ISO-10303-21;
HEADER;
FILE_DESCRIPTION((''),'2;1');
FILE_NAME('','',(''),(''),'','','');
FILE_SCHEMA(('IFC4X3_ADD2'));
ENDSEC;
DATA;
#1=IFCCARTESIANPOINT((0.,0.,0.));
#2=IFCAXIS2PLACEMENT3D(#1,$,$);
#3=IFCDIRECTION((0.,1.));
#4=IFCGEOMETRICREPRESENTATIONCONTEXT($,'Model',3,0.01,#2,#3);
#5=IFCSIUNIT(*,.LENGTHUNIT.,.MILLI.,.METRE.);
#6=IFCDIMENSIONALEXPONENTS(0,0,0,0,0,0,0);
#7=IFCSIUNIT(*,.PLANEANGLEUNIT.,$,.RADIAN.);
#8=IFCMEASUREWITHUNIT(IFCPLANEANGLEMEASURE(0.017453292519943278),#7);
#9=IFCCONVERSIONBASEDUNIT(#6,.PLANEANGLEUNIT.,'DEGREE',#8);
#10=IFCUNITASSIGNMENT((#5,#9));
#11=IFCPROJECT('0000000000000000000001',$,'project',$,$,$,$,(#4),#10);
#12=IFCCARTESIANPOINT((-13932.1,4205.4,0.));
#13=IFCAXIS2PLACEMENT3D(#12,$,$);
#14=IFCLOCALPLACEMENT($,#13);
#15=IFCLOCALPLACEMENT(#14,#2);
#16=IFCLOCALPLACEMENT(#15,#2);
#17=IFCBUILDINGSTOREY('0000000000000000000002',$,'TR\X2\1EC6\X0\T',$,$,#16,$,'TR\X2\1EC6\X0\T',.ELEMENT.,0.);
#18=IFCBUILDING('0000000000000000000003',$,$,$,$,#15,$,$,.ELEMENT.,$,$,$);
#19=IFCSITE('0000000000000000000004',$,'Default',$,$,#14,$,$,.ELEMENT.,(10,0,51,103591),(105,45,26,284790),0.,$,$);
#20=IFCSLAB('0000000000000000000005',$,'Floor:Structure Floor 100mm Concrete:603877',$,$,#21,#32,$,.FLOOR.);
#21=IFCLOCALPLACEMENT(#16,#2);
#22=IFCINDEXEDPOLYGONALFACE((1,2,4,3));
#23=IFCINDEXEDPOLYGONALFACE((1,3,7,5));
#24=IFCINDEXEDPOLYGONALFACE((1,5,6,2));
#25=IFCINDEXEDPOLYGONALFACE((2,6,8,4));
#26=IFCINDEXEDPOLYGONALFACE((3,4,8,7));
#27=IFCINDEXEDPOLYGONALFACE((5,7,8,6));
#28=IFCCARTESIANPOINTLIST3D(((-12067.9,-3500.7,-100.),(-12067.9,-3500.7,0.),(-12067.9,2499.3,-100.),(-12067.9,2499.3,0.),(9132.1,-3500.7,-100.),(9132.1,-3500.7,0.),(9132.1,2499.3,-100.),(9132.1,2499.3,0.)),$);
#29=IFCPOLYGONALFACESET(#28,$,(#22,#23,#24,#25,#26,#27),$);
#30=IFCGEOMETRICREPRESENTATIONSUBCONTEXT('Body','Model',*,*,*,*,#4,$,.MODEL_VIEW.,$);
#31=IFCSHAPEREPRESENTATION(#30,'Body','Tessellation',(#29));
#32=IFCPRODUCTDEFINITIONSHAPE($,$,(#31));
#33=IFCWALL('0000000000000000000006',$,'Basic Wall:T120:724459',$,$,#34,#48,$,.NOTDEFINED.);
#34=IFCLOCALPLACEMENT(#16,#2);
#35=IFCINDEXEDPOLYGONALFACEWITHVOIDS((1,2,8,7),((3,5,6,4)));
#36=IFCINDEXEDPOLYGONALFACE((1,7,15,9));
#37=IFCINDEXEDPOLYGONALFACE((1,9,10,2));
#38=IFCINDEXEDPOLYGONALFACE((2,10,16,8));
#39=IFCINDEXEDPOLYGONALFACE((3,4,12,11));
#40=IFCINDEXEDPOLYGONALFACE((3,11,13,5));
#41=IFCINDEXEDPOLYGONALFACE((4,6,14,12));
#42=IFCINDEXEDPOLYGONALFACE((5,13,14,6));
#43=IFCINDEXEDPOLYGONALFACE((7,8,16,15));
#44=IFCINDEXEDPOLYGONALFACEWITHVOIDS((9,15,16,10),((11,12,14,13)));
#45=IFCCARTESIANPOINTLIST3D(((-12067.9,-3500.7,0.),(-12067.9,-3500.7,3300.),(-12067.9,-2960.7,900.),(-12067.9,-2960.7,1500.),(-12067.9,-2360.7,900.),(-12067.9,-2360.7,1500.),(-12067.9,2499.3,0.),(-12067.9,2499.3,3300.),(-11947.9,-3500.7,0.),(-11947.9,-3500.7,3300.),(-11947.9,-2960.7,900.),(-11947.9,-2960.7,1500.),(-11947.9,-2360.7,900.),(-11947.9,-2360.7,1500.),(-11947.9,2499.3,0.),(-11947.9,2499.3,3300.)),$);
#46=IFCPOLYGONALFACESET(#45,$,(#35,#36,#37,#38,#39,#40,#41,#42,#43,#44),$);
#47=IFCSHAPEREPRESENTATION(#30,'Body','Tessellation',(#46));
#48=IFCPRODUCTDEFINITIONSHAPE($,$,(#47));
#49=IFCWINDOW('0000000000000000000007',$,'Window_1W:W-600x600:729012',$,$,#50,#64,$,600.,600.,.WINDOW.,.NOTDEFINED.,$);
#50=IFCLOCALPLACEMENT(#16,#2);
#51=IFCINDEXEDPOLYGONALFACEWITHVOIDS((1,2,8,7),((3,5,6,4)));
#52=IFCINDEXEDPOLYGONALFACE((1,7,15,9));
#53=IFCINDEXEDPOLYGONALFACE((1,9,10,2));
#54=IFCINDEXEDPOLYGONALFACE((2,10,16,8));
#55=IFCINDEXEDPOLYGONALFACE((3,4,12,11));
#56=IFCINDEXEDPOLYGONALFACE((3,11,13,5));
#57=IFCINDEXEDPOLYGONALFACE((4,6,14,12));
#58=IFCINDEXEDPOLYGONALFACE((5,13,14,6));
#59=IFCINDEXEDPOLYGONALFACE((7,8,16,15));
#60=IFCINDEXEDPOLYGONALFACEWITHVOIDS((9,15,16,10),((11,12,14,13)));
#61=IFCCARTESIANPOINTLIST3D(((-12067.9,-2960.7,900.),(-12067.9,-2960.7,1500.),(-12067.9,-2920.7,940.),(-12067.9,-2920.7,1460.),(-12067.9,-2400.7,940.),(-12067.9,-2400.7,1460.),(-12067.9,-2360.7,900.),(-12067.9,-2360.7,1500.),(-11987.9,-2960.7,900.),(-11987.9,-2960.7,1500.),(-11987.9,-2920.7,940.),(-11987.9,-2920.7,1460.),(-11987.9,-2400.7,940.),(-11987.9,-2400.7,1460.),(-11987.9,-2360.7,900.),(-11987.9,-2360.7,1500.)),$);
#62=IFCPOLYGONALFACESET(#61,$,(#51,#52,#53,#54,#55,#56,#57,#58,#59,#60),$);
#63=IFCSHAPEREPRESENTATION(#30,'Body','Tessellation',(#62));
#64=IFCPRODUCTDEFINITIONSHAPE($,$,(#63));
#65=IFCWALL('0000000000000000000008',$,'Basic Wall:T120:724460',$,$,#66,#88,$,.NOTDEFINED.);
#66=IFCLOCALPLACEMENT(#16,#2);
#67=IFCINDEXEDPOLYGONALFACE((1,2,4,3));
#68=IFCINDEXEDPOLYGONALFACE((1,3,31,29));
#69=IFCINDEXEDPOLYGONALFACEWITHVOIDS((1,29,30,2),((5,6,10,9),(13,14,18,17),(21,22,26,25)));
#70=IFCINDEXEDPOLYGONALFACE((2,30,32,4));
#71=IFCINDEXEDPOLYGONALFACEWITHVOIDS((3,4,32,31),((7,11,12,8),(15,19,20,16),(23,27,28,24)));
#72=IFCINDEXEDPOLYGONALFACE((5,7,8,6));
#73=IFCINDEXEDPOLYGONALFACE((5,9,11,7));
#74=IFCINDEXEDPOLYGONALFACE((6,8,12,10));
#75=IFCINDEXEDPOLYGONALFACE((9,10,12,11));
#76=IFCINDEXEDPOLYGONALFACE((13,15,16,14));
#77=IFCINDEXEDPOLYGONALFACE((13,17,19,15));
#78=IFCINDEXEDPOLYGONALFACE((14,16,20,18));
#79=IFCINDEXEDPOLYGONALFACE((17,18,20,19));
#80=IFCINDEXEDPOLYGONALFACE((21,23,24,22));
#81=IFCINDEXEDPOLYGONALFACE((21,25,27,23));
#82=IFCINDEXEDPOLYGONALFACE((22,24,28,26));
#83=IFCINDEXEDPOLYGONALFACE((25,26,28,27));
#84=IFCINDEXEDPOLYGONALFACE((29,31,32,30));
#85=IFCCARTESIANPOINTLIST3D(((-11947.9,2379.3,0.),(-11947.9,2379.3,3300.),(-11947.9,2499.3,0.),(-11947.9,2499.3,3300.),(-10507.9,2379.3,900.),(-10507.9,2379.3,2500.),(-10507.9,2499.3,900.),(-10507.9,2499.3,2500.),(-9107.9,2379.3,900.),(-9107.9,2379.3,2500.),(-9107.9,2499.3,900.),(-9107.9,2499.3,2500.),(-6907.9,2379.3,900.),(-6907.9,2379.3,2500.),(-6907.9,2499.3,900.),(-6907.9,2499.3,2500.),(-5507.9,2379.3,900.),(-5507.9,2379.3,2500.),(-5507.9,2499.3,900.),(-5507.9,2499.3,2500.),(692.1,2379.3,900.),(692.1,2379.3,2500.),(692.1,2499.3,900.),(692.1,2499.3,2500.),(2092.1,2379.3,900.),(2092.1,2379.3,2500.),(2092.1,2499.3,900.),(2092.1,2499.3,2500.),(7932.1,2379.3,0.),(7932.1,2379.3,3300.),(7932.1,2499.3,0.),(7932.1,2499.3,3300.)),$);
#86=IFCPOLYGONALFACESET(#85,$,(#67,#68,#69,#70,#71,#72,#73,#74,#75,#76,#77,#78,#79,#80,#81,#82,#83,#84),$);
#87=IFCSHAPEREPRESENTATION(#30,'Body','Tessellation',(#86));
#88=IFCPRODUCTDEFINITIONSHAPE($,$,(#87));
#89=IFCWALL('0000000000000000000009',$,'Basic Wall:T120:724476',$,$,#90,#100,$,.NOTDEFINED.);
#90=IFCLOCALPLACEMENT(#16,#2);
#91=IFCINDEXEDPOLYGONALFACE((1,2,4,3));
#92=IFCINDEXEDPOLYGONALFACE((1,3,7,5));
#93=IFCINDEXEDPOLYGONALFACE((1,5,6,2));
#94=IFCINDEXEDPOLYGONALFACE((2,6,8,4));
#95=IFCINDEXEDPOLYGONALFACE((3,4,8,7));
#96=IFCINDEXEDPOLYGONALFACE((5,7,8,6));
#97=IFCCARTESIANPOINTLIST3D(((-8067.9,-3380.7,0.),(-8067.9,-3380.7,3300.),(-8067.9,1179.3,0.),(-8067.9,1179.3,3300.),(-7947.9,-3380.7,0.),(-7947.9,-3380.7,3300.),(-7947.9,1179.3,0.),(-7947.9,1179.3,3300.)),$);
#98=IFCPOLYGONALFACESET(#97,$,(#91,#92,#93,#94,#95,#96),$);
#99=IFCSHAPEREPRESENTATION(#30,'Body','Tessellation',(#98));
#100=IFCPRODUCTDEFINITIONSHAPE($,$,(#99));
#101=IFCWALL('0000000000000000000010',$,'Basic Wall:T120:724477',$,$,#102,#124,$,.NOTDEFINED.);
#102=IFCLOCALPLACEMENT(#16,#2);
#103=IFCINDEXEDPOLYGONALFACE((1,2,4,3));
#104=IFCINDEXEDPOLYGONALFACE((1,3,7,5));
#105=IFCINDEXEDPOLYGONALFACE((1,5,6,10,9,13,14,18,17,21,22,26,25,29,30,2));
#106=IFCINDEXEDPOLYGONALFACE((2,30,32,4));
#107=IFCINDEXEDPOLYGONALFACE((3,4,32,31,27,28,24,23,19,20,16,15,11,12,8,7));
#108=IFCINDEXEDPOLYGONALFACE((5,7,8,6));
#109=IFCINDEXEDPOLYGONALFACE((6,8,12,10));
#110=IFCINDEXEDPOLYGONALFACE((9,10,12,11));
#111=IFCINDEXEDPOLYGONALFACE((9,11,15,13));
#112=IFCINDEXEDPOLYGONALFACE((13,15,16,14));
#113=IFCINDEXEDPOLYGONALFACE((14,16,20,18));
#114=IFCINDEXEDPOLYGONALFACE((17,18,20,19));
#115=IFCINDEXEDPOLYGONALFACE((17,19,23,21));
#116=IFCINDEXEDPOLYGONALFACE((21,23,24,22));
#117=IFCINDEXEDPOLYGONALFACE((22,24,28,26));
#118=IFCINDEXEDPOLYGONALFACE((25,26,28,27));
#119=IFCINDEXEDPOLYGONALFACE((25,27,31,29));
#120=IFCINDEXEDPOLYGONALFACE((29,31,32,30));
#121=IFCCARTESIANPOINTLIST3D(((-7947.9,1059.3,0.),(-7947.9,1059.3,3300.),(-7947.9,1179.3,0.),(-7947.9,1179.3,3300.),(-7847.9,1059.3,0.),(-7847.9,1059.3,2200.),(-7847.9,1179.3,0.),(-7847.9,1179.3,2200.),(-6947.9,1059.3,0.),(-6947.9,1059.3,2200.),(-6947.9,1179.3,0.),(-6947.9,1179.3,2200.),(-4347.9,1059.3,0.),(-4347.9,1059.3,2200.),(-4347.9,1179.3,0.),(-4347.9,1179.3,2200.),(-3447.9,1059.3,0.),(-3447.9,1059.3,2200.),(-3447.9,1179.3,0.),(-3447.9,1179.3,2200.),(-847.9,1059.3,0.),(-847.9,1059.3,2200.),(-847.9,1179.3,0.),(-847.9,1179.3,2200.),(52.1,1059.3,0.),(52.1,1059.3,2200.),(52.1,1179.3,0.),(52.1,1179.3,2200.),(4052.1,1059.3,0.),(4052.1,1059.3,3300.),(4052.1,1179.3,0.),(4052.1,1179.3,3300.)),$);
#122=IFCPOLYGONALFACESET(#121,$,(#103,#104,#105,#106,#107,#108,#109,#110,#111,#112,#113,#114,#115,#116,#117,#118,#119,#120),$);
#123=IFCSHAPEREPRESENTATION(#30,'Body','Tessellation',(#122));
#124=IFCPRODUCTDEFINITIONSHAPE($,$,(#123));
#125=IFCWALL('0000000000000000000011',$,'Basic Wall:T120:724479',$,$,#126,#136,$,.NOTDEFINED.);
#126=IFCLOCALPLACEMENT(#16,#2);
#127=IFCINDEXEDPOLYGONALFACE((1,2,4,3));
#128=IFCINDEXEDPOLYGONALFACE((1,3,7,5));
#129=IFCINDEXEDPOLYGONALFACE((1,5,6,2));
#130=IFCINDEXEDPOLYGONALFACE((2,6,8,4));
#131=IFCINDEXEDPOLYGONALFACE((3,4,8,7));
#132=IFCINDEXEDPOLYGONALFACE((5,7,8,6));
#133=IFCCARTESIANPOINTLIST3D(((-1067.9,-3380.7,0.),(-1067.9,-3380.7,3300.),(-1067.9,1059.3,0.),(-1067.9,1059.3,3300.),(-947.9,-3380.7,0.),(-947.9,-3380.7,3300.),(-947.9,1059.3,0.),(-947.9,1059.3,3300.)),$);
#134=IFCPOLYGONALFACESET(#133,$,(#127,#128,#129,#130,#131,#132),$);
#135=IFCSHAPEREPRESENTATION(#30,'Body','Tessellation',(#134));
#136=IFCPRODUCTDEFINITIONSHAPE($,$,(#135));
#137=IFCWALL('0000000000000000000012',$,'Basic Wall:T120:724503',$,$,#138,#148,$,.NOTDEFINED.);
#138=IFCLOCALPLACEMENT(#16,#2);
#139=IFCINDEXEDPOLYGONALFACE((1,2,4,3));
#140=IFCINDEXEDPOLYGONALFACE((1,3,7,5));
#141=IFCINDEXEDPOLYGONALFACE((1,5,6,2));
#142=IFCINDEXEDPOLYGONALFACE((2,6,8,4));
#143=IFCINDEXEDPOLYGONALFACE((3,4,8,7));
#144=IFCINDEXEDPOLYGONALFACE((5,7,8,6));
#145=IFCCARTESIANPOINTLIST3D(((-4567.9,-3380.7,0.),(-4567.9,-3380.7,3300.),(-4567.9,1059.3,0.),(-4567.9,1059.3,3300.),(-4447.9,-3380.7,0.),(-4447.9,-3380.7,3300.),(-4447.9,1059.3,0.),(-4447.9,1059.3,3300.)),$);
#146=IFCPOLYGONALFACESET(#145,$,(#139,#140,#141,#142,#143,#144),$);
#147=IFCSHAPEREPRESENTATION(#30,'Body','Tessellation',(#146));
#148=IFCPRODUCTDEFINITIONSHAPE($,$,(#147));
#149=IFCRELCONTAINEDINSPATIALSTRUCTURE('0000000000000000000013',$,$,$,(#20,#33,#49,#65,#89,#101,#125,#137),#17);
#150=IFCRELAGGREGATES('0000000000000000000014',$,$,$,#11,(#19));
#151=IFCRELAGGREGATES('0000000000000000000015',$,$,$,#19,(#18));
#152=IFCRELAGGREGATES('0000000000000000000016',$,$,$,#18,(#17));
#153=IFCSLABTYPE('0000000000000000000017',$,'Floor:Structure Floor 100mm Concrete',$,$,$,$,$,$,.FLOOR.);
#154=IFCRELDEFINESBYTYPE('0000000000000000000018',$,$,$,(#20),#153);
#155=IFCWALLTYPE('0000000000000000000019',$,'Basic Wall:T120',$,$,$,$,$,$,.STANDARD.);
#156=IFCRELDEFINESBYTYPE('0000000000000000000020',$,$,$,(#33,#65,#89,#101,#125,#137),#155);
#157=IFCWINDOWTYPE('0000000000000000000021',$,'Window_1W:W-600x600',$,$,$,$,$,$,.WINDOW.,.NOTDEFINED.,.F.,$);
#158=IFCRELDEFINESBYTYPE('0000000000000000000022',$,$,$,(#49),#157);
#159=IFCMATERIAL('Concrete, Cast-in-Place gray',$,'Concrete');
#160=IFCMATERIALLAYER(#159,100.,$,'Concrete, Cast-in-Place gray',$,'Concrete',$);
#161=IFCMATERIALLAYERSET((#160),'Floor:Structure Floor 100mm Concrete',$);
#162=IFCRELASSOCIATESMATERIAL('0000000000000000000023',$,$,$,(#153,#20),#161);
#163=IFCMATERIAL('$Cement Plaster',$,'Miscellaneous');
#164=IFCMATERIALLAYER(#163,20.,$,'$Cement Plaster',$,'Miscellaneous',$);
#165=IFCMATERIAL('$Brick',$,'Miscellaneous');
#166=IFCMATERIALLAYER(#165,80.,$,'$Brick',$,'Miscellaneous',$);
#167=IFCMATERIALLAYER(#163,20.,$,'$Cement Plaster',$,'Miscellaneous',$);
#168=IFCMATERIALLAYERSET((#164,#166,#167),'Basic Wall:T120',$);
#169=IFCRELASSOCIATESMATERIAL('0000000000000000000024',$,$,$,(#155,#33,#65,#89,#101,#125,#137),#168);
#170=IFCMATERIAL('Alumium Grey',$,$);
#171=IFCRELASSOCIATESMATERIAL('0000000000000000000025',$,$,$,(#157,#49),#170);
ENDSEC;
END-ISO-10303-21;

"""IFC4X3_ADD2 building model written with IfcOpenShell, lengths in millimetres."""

from ifc_helpers import new_model, entity, si_unit, converted_unit, direction, frame, frame_2d, origin, origin_2d_with_axis, place, context, subcontext, project, spatial, polyline, rectangle, outline, extrude, source, transform, mapped, material, layer, layer_set, layer_usage, type_object, type_shapes, element, fill, save


model = new_model("IFC4X3_ADD2")

# Units and contexts
model_context = context("Model", 3, precision=0.01, world=origin(), true_north=direction((0.0, 1.0)))
body_context = subcontext(model_context, "Body", "Model", "MODEL_VIEW")
ifc_project = project(units=[si_unit("LENGTHUNIT", "METRE", prefix="MILLI"), converted_unit("PLANEANGLEUNIT", "DEGREE", entity("IfcPlaneAngleMeasure", 0.017453292519943278), si_unit("PLANEANGLEUNIT", "RADIAN"), dimensions=[0, 0, 0, 0, 0, 0, 0])], contexts=[model_context])

# Site, building, storey
site_placement = place(None, frame((-13932.1, 4205.4, 0.0)))
site = spatial("IfcSite", under=ifc_project, at=site_placement, Name="Default", CompositionType="ELEMENT", RefLatitude=(10, 0, 51, 103591), RefLongitude=(105, 45, 26, 284790), RefElevation=0.0)
building_placement = place(site_placement, origin())
building = spatial("IfcBuilding", under=site, at=building_placement, CompositionType="ELEMENT")
storey_placement = place(building_placement, origin())
storey = spatial("IfcBuildingStorey", under=building, at=storey_placement, Name="TRỆT", LongName="TRỆT", CompositionType="ELEMENT", Elevation=0.0)

# Shared definitions
ifc_material_1 = material(Name="Concrete, Cast-in-Place gray", Category="Concrete")

# Slab
ifc_layer_1 = layer(ifc_material_1, 100.0, Name="Concrete, Cast-in-Place gray", Category="Concrete")
ifc_layer_set_1 = layer_set([ifc_layer_1], Name="Floor:Structure Floor 100mm Concrete")
ifc_layer_usage = layer_usage(ifc_layer_set_1, "AXIS3", "POSITIVE", 0.0)
slab_type = type_object("IfcSlabType", Name="Floor:Structure Floor 100mm Concrete", PredefinedType="FLOOR", material=ifc_layer_set_1)
slab_placement = place(storey_placement, origin())
element("IfcSlab", 1, at=slab_placement, inside=storey, type_object=slab_type, material=ifc_layer_usage, Name="Floor:Structure Floor 100mm Concrete:603877", PredefinedType="FLOOR", context=body_context, shape_type="SweptSolid", body=[
    extrude(rectangle(XDim=6000.0, YDim=21200.0, at=origin_2d_with_axis()), frame((-1467.9, -500.7, 0.0), z_axis=(0.0, 0.0, -1.0), x_axis=(0.0, 1.0, 0.0)), (0.0, 0.0, 1.0), 100.0),
])

# Wall, opening, window
ifc_material_2 = material(Name="$Cement Plaster", Category="Miscellaneous")
ifc_layer_2 = layer(ifc_material_2, 20.0, Name="$Cement Plaster", Category="Miscellaneous")
ifc_material_3 = material(Name="$Brick", Category="Miscellaneous")
ifc_layer_3 = layer(ifc_material_3, 80.0, Name="$Brick", Category="Miscellaneous")
ifc_layer_4 = layer(ifc_material_2, 20.0, Name="$Cement Plaster", Category="Miscellaneous")
ifc_layer_set_2 = layer_set([ifc_layer_2, ifc_layer_3, ifc_layer_4], Name="Basic Wall:T120")
wall_type = type_object("IfcWallType", Name="Basic Wall:T120", PredefinedType="STANDARD", material=ifc_layer_set_2)
wall_1_placement = place(storey_placement, frame((-12007.9, -3500.7, 0.0), z_axis=(0.0, 0.0, 1.0), x_axis=(0.0, 1.0, 0.0)))
wall_1 = element("IfcWall", 2, at=wall_1_placement, inside=storey, type_object=wall_type, material=ifc_layer_set_2, Name="Basic Wall:T120:724459", PredefinedType="NOTDEFINED", context=body_context, shape_type="SweptSolid", body=[
    extrude(rectangle(XDim=6000.0, YDim=120.0, at=frame_2d((3000.0, 0.0), x_axis=(-1.0, 0.0))), origin(), (0.0, 0.0, 1.0), 3300.0),
])
opening_1_placement = place(wall_1_placement, frame((540.0, -60.0, 900.0)))
opening_1 = element("IfcOpeningElement", 3, at=opening_1_placement, cuts=wall_1, PredefinedType="OPENING", context=body_context, shape_type="SweptSolid", body=[
    extrude(rectangle(XDim=600.0, YDim=600.0, at=frame_2d((300.0, 300.0), x_axis=(1.0, 0.0))), frame((0.0, 0.0, 0.0), z_axis=(0.0, 1.0, 0.0), x_axis=(0.0, 0.0, 1.0)), (0.0, 0.0, 1.0), 120.0),
])
ifc_material_4 = material(Name="Alumium Grey")
window_type = type_object("IfcWindowType", Name="Window_1W:W-600x600", ParameterTakesPrecedence=False, PartitioningType="NOTDEFINED", PredefinedType="WINDOW", material=ifc_material_4)
shared_shape_1 = source(origin(), body_context, "Body", "SweptSolid", [
    extrude(outline(polyline([(-300.0, -300.0), (300.0, -300.0), (300.0, 300.0), (-300.0, 300.0), (-300.0, -300.0)]), holes=[polyline([(-260.0, -260.0), (-260.0, 260.0), (260.0, 260.0), (260.0, -260.0), (-260.0, -260.0)])]), frame((300.0, 40.0, 300.0), z_axis=(0.0, 1.0, 0.0), x_axis=(1.0, 0.0, 0.0)), (0.0, 0.0, 1.0), 80.0),
])
type_shapes(window_type, [shared_shape_1])
window_placement = place(opening_1_placement, origin())
window = element("IfcWindow", 4, at=window_placement, inside=storey, type_object=window_type, material=ifc_material_4, Name="Window_1W:W-600x600:729012", OverallHeight=600.0, OverallWidth=600.0, PartitioningType="NOTDEFINED", PredefinedType="WINDOW", context=body_context, shape_type="MappedRepresentation", body=[
    mapped(shared_shape_1, transform((0.0, 0.0, 0.0), scale=1.0)),
])
fill(opening_1, window)

# Wall, openings
wall_2_placement = place(storey_placement, frame((-11947.9, 2439.3, 0.0)))
wall_2 = element("IfcWall", 5, at=wall_2_placement, inside=storey, type_object=wall_type, material=ifc_layer_set_2, Name="Basic Wall:T120:724460", PredefinedType="NOTDEFINED", context=body_context, shape_type="SweptSolid", body=[
    extrude(rectangle(XDim=19880.0, YDim=120.0, at=frame_2d((9940.0, 0.0), x_axis=(-1.0, 0.0))), origin(), (0.0, 0.0, 1.0), 3300.0),
])
opening_2_placement = place(wall_2_placement, frame((1440.0, -60.0, 900.0)))
element("IfcOpeningElement", 6, at=opening_2_placement, cuts=wall_2, PredefinedType="OPENING", context=body_context, shape_type="SweptSolid", body=[
    extrude(rectangle(XDim=1600.0, YDim=1400.0, at=frame_2d((800.0, 700.0), x_axis=(1.0, 0.0))), frame((0.0, 0.0, 0.0), z_axis=(0.0, 1.0, 0.0), x_axis=(0.0, 0.0, 1.0)), (0.0, 0.0, 1.0), 120.0),
])
opening_3_placement = place(wall_2_placement, frame((12640.0, -60.0, 900.0)))
element("IfcOpeningElement", 7, at=opening_3_placement, cuts=wall_2, PredefinedType="OPENING", context=body_context, shape_type="SweptSolid", body=[
    extrude(rectangle(XDim=1600.0, YDim=1400.0, at=frame_2d((800.0, 700.0), x_axis=(1.0, 0.0))), frame((0.0, 0.0, 0.0), z_axis=(0.0, 1.0, 0.0), x_axis=(0.0, 0.0, 1.0)), (0.0, 0.0, 1.0), 120.0),
])
opening_4_placement = place(wall_2_placement, frame((5040.0, -60.0, 900.0)))
element("IfcOpeningElement", 8, at=opening_4_placement, cuts=wall_2, PredefinedType="OPENING", context=body_context, shape_type="SweptSolid", body=[
    extrude(rectangle(XDim=1600.0, YDim=1400.0, at=frame_2d((800.0, 700.0), x_axis=(1.0, 0.0))), frame((0.0, 0.0, 0.0), z_axis=(0.0, 1.0, 0.0), x_axis=(0.0, 0.0, 1.0)), (0.0, 0.0, 1.0), 120.0),
])

# Wall
wall_3_placement = place(storey_placement, frame((-8007.9, -3380.7, 0.0), z_axis=(0.0, 0.0, 1.0), x_axis=(0.0, 1.0, 0.0)))
element("IfcWall", 9, at=wall_3_placement, inside=storey, type_object=wall_type, material=ifc_layer_set_2, Name="Basic Wall:T120:724476", PredefinedType="NOTDEFINED", context=body_context, shape_type="SweptSolid", body=[
    extrude(rectangle(XDim=4560.0, YDim=120.0, at=frame_2d((2280.0, 0.0), x_axis=(-1.0, 0.0))), origin(), (0.0, 0.0, 1.0), 3300.0),
])

# Wall, openings
wall_4_placement = place(storey_placement, frame((-7947.9, 1119.3, 0.0)))
wall_4 = element("IfcWall", 10, at=wall_4_placement, inside=storey, type_object=wall_type, material=ifc_layer_set_2, Name="Basic Wall:T120:724477", PredefinedType="NOTDEFINED", context=body_context, shape_type="SweptSolid", body=[
    extrude(rectangle(XDim=12000.0, YDim=120.0, at=frame_2d((6000.0, 0.0), x_axis=(-1.0, 0.0))), origin(), (0.0, 0.0, 1.0), 3300.0),
])
opening_5_placement = place(wall_4_placement, frame((8000.0, 60.0, 0.0)))
element("IfcOpeningElement", 11, at=opening_5_placement, cuts=wall_4, PredefinedType="OPENING", context=body_context, shape_type="SweptSolid", body=[
    extrude(rectangle(XDim=2200.0, YDim=900.0, at=frame_2d((1100.0, 450.0), x_axis=(1.0, 0.0))), frame((0.0, 0.0, 0.0), z_axis=(0.0, -1.0, 0.0), x_axis=(0.0, 0.0, 1.0)), (0.0, 0.0, 1.0), 120.0),
])
opening_6_placement = place(wall_4_placement, frame((4500.0, 60.0, 0.0)))
element("IfcOpeningElement", 12, at=opening_6_placement, cuts=wall_4, PredefinedType="OPENING", context=body_context, shape_type="SweptSolid", body=[
    extrude(rectangle(XDim=2200.0, YDim=900.0, at=frame_2d((1100.0, 450.0), x_axis=(1.0, 0.0))), frame((0.0, 0.0, 0.0), z_axis=(0.0, -1.0, 0.0), x_axis=(0.0, 0.0, 1.0)), (0.0, 0.0, 1.0), 120.0),
])
opening_7_placement = place(wall_4_placement, frame((1000.0, 60.0, 0.0)))
element("IfcOpeningElement", 13, at=opening_7_placement, cuts=wall_4, PredefinedType="OPENING", context=body_context, shape_type="SweptSolid", body=[
    extrude(rectangle(XDim=2200.0, YDim=900.0, at=frame_2d((1100.0, 450.0), x_axis=(1.0, 0.0))), frame((0.0, 0.0, 0.0), z_axis=(0.0, -1.0, 0.0), x_axis=(0.0, 0.0, 1.0)), (0.0, 0.0, 1.0), 120.0),
])

# Walls
wall_5_placement = place(storey_placement, frame((-1007.9, -3380.7, 0.0), z_axis=(0.0, 0.0, 1.0), x_axis=(0.0, 1.0, 0.0)))
element("IfcWall", 14, at=wall_5_placement, inside=storey, type_object=wall_type, material=ifc_layer_set_2, Name="Basic Wall:T120:724479", PredefinedType="NOTDEFINED", context=body_context, shape_type="SweptSolid", body=[
    extrude(rectangle(XDim=4440.0, YDim=120.0, at=frame_2d((2220.0, 0.0), x_axis=(-1.0, 0.0))), origin(), (0.0, 0.0, 1.0), 3300.0),
])
wall_6_placement = place(storey_placement, frame((-4507.9, -3380.7, 0.0), z_axis=(0.0, 0.0, 1.0), x_axis=(0.0, 1.0, 0.0)))
element("IfcWall", 15, at=wall_6_placement, inside=storey, type_object=wall_type, material=ifc_layer_set_2, Name="Basic Wall:T120:724503", PredefinedType="NOTDEFINED", context=body_context, shape_type="SweptSolid", body=[
    extrude(rectangle(XDim=4440.0, YDim=120.0, at=frame_2d((2220.0, 0.0), x_axis=(-1.0, 0.0))), origin(), (0.0, 0.0, 1.0), 3300.0),
])

save(model, "model.ifc")
